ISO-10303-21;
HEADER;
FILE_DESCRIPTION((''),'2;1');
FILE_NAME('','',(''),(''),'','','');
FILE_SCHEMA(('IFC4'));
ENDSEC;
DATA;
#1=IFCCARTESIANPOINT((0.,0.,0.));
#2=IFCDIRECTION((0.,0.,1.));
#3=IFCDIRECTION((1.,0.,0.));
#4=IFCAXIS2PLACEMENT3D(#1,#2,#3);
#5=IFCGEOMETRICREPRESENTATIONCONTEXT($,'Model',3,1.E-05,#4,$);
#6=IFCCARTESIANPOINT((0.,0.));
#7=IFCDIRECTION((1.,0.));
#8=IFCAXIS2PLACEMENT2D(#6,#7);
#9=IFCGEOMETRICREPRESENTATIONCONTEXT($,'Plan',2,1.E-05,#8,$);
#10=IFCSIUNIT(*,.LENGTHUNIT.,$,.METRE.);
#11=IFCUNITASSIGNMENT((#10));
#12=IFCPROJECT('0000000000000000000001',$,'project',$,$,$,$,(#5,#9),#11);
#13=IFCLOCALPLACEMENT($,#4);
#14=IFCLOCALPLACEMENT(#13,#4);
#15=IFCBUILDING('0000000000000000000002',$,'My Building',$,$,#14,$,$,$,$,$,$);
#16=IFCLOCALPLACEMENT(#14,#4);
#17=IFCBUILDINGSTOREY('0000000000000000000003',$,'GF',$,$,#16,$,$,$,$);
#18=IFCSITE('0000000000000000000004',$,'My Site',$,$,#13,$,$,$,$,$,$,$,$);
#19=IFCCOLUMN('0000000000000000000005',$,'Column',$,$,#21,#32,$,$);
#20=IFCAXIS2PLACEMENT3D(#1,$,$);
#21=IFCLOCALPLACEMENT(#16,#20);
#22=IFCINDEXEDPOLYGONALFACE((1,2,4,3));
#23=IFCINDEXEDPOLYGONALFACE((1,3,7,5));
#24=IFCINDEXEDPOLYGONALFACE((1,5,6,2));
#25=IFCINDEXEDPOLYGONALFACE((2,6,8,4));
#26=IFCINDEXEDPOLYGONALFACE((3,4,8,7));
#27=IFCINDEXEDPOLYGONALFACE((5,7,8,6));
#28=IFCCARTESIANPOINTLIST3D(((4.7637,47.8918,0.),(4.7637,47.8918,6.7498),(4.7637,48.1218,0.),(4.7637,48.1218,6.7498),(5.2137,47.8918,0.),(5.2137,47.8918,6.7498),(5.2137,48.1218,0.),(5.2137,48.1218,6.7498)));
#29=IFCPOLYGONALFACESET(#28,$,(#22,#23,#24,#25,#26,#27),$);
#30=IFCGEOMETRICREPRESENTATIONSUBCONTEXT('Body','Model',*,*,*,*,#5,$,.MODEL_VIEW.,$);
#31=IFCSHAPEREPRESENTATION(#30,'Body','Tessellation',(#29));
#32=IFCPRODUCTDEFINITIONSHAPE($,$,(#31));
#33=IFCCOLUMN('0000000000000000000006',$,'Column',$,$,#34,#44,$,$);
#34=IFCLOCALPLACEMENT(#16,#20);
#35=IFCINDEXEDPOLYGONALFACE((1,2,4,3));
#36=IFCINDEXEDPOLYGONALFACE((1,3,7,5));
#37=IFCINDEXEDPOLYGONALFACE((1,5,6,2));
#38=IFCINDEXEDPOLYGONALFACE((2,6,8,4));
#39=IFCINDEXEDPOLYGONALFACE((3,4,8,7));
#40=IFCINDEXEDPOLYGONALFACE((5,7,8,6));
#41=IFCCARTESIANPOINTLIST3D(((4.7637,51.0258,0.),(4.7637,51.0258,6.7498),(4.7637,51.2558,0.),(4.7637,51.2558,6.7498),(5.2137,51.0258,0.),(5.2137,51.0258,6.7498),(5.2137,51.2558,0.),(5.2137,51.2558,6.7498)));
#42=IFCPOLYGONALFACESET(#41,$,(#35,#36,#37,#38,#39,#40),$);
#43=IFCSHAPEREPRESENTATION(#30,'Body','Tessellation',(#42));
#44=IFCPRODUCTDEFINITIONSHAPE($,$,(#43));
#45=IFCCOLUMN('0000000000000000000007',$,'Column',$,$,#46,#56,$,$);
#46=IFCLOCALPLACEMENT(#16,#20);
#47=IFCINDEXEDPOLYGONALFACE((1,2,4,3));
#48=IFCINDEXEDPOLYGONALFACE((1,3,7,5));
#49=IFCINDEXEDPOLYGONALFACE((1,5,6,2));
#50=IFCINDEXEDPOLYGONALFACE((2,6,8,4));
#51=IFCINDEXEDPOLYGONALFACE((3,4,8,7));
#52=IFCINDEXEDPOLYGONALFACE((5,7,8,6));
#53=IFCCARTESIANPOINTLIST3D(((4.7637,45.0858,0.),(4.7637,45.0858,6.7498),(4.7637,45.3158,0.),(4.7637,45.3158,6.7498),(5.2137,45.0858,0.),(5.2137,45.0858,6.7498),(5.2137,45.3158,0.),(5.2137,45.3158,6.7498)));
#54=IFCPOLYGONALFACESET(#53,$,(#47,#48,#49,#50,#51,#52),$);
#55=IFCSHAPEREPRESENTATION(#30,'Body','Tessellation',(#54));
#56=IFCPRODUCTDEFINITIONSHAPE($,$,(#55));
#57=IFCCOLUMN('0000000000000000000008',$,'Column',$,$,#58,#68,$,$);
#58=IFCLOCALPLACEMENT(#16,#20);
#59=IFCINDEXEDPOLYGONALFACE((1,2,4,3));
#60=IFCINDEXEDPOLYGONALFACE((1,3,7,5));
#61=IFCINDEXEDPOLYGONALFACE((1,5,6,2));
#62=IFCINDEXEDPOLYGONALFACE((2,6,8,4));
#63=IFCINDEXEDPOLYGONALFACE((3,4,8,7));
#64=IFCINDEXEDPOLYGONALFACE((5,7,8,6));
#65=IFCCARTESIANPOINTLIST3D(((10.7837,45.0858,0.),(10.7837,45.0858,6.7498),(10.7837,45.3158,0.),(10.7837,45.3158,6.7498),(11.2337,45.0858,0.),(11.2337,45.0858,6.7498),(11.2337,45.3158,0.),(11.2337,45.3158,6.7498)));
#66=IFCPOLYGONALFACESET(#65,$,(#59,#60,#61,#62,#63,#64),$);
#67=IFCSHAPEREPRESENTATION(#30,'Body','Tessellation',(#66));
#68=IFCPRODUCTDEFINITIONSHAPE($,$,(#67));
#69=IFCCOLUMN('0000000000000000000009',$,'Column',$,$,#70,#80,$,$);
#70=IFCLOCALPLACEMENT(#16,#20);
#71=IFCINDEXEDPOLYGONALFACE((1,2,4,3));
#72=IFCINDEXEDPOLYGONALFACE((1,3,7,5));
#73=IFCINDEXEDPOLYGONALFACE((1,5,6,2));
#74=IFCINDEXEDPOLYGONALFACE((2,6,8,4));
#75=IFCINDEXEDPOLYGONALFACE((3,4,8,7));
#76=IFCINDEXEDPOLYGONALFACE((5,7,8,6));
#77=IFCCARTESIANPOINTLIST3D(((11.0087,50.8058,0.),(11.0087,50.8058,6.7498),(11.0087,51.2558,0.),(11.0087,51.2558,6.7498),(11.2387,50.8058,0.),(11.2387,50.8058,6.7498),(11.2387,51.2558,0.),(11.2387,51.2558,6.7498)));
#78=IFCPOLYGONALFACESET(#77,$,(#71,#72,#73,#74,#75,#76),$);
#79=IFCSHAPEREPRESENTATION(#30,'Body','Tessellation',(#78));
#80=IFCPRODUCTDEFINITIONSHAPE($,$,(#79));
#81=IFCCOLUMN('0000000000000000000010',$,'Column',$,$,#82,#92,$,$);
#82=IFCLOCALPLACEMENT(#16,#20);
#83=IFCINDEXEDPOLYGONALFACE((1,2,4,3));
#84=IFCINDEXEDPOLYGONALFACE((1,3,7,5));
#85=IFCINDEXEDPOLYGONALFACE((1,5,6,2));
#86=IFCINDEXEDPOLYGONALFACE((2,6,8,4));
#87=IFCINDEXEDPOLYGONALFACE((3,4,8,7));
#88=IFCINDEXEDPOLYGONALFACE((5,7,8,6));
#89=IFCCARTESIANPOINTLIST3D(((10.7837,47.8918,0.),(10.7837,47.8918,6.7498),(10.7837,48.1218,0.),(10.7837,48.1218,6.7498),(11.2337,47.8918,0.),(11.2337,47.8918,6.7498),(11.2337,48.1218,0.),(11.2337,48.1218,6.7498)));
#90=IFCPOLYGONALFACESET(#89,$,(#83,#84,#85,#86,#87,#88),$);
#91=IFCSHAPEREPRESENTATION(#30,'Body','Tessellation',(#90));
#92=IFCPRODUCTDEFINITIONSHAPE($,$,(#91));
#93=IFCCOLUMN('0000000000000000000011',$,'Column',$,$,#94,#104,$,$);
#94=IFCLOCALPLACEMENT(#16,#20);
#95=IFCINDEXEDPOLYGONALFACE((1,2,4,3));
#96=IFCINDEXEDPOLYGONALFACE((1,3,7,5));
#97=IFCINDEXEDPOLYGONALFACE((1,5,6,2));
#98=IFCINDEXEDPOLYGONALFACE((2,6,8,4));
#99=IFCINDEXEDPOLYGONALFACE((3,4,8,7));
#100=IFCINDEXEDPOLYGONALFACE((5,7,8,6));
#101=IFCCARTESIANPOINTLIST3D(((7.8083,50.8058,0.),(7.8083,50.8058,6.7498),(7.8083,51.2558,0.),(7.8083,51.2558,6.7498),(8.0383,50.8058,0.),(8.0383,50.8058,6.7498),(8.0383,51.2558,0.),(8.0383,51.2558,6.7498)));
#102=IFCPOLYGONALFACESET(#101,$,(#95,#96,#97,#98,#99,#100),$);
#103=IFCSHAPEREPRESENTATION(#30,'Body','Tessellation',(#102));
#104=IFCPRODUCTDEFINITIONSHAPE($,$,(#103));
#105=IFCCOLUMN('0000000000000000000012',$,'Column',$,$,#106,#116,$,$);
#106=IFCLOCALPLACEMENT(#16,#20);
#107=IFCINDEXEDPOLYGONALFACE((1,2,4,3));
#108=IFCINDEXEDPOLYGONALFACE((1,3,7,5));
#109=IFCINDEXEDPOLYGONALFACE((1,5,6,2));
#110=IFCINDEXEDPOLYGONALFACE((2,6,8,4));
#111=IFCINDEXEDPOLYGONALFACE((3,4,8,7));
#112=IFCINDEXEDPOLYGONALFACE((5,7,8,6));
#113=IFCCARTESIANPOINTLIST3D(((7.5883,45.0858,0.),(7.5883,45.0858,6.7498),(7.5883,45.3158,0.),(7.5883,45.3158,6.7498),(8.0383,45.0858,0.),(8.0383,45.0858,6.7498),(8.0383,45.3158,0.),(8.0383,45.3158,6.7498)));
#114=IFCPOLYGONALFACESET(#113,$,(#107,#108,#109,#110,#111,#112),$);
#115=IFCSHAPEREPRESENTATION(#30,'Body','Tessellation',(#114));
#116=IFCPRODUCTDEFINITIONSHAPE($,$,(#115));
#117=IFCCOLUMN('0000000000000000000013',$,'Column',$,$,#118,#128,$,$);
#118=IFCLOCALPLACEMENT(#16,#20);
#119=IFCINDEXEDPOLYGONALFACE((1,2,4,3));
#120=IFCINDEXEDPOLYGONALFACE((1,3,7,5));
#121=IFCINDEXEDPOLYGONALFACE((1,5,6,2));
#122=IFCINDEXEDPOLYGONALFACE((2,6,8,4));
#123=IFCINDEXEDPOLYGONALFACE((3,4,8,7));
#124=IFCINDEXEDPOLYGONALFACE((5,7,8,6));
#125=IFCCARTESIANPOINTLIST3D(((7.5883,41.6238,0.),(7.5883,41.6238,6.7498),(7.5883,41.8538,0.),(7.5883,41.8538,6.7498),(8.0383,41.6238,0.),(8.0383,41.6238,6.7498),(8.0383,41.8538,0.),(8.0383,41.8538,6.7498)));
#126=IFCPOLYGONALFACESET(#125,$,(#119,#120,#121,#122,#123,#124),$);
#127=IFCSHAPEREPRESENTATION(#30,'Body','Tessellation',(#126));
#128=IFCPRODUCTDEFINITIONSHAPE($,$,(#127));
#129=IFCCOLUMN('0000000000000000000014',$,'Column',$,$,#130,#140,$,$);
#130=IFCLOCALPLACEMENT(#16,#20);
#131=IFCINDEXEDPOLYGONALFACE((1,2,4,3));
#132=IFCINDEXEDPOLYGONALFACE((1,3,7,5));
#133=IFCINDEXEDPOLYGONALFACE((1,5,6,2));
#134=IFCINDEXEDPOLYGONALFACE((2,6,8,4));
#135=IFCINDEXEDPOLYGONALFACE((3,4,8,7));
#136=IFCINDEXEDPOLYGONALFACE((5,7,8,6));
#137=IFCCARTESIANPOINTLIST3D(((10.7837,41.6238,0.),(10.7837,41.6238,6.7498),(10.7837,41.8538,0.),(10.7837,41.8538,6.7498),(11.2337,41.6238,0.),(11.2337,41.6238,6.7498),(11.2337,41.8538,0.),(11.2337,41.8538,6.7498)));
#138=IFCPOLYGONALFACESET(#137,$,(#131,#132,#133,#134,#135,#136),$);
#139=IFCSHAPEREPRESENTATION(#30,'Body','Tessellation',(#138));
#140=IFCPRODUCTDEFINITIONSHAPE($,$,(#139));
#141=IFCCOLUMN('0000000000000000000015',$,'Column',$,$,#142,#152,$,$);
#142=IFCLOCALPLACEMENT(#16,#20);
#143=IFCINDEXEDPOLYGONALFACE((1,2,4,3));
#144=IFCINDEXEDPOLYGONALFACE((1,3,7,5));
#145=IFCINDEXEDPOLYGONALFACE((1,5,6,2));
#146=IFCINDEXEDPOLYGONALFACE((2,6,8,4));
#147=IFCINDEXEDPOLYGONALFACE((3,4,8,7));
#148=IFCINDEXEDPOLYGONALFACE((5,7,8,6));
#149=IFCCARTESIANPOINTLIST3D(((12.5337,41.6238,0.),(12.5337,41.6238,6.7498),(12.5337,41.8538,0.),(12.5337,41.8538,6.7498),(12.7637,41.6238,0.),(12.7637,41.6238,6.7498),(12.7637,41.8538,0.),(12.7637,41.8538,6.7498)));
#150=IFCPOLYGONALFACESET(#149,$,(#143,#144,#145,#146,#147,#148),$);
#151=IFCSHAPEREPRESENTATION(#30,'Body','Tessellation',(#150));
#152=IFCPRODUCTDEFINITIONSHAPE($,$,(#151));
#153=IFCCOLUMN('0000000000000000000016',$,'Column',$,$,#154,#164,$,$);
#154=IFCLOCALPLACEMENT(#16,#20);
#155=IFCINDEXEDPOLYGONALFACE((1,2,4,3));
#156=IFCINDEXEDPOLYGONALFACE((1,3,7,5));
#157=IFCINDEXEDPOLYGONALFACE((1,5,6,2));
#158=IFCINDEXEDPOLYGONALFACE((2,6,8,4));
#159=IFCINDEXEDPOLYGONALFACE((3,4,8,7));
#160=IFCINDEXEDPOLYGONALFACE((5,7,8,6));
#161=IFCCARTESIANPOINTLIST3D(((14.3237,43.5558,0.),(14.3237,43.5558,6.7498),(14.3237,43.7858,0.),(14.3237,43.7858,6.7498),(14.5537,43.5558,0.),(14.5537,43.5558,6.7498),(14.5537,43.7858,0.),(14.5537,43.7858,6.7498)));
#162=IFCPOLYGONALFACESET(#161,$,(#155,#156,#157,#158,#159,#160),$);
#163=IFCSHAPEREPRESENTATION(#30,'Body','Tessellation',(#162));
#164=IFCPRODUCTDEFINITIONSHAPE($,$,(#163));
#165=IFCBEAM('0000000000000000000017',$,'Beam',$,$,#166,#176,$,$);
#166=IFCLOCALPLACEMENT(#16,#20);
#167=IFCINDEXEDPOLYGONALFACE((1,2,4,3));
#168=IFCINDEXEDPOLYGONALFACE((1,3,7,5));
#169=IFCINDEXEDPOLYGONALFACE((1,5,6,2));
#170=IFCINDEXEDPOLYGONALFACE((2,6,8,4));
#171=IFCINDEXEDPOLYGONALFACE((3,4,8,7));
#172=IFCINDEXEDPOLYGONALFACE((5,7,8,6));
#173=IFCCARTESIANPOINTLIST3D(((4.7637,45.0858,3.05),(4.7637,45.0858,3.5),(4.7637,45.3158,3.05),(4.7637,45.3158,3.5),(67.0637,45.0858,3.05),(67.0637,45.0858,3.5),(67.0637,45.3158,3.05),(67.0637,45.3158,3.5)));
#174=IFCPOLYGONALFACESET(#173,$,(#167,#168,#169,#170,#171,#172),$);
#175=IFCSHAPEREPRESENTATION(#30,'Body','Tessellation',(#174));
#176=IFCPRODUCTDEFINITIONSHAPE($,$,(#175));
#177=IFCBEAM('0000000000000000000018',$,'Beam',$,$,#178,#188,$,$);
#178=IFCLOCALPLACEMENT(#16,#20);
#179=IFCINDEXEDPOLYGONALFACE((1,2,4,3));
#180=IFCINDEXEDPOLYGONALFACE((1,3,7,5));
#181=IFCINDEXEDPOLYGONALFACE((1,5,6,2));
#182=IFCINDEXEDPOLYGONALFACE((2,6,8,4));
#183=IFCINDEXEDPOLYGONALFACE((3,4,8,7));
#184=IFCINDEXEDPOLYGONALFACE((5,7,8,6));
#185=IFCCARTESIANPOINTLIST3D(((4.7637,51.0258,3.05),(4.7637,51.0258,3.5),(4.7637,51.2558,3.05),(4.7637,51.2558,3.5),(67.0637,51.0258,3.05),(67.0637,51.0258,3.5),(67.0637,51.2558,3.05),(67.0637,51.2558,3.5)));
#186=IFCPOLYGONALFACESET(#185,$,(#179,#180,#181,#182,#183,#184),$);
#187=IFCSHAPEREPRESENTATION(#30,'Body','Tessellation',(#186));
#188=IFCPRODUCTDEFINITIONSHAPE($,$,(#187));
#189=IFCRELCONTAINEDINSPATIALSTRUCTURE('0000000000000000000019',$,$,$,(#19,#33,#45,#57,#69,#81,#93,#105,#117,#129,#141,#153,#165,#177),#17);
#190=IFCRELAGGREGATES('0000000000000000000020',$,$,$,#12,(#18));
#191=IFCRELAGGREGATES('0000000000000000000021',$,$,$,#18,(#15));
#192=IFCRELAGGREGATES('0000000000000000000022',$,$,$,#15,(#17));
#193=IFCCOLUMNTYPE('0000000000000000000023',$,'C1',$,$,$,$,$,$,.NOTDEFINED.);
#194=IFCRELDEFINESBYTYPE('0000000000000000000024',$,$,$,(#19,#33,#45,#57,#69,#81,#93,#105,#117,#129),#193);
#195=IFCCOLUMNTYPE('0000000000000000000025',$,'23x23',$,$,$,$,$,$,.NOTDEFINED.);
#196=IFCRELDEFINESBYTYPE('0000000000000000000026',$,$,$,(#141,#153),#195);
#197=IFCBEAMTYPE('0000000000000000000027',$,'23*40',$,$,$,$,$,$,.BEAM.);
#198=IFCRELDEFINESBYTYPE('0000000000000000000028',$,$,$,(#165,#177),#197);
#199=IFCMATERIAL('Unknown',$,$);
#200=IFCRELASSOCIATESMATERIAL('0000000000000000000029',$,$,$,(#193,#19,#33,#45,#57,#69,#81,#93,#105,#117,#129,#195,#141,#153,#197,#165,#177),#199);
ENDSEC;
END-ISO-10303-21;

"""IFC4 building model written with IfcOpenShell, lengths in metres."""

from ifc_helpers import new_model, si_unit, frame, origin_with_axes, origin_2d_with_axis, place, context, subcontext, project, spatial, rectangle, extrude, material, material_profile, profile_set, profile_usage, type_object, element, save


model = new_model("IFC4")

# Units and contexts
model_context = context("Model", 3, precision=1e-05, world=origin_with_axes())
plan_context = context("Plan", 2, precision=1e-05, world=origin_2d_with_axis())
body_context = subcontext(model_context, "Body", "Model", "MODEL_VIEW")
ifc_project = project(units=[si_unit("LENGTHUNIT", "METRE")], contexts=[model_context, plan_context])

# Site, building, storey
site_placement = place(None, origin_with_axes())
site = spatial("IfcSite", under=ifc_project, at=site_placement, Name="My Site")
building_placement = place(site_placement, origin_with_axes())
building = spatial("IfcBuilding", under=site, at=building_placement, Name="My Building")
storey_placement = place(building_placement, origin_with_axes())
storey = spatial("IfcBuildingStorey", under=building, at=storey_placement, Name="GF")

# Columns
ifc_material = material(Name="Unknown")
ifc_material_profile_1 = material_profile(ifc_material, rectangle(XDim=0.45, YDim=0.23))
ifc_profile_set_1 = profile_set([ifc_material_profile_1])
ifc_profile_usage_1 = profile_usage(ifc_profile_set_1, cardinal=5)
column_type_1 = type_object("IfcColumnType", Name="C1", PredefinedType="NOTDEFINED", material=ifc_profile_set_1)
column_1_placement = place(storey_placement, frame((4.9887, 48.0068, 0.0), z_axis=(0.0, 0.0, 1.0), x_axis=(1.0, 0.0, 0.0)))
element("IfcColumn", 1, at=column_1_placement, inside=storey, type_object=column_type_1, material=ifc_profile_usage_1, Name="Column", context=body_context, shape_type="SweptSolid", body=[
    extrude(rectangle(XDim=0.45, YDim=0.23), origin_with_axes(), (0.0, 0.0, 1.0), 6.7498),
])
ifc_profile_usage_2 = profile_usage(ifc_profile_set_1, cardinal=5)
column_2_placement = place(storey_placement, frame((4.9887, 51.1408, 0.0), z_axis=(0.0, 0.0, 1.0), x_axis=(1.0, 0.0, 0.0)))
element("IfcColumn", 2, at=column_2_placement, inside=storey, type_object=column_type_1, material=ifc_profile_usage_2, Name="Column", context=body_context, shape_type="SweptSolid", body=[
    extrude(rectangle(XDim=0.45, YDim=0.23), origin_with_axes(), (0.0, 0.0, 1.0), 6.7498),
])
ifc_profile_usage_3 = profile_usage(ifc_profile_set_1, cardinal=5)
column_3_placement = place(storey_placement, frame((4.9887, 45.2008, 0.0), z_axis=(0.0, 0.0, 1.0), x_axis=(1.0, 0.0, 0.0)))
element("IfcColumn", 3, at=column_3_placement, inside=storey, type_object=column_type_1, material=ifc_profile_usage_3, Name="Column", context=body_context, shape_type="SweptSolid", body=[
    extrude(rectangle(XDim=0.45, YDim=0.23), origin_with_axes(), (0.0, 0.0, 1.0), 6.7498),
])
ifc_profile_usage_4 = profile_usage(ifc_profile_set_1, cardinal=5)
column_4_placement = place(storey_placement, frame((11.0087, 45.2008, 0.0), z_axis=(0.0, 0.0, 1.0), x_axis=(-1.0, 0.0, 0.0)))
element("IfcColumn", 4, at=column_4_placement, inside=storey, type_object=column_type_1, material=ifc_profile_usage_4, Name="Column", context=body_context, shape_type="SweptSolid", body=[
    extrude(rectangle(XDim=0.45, YDim=0.23), origin_with_axes(), (0.0, 0.0, 1.0), 6.7498),
])
ifc_profile_usage_5 = profile_usage(ifc_profile_set_1, cardinal=5)
column_5_placement = place(storey_placement, frame((11.1237, 51.0308, 0.0), z_axis=(0.0, 0.0, 1.0), x_axis=(0.0, 1.0, 0.0)))
element("IfcColumn", 5, at=column_5_placement, inside=storey, type_object=column_type_1, material=ifc_profile_usage_5, Name="Column", context=body_context, shape_type="SweptSolid", body=[
    extrude(rectangle(XDim=0.45, YDim=0.23), origin_with_axes(), (0.0, 0.0, 1.0), 6.7498),
])
ifc_profile_usage_6 = profile_usage(ifc_profile_set_1, cardinal=5)
column_6_placement = place(storey_placement, frame((11.0087, 48.0068, 0.0), z_axis=(0.0, 0.0, 1.0), x_axis=(-1.0, 0.0, 0.0)))
element("IfcColumn", 6, at=column_6_placement, inside=storey, type_object=column_type_1, material=ifc_profile_usage_6, Name="Column", context=body_context, shape_type="SweptSolid", body=[
    extrude(rectangle(XDim=0.45, YDim=0.23), origin_with_axes(), (0.0, 0.0, 1.0), 6.7498),
])
ifc_profile_usage_7 = profile_usage(ifc_profile_set_1, cardinal=5)
column_7_placement = place(storey_placement, frame((7.9233, 51.0308, 0.0), z_axis=(0.0, 0.0, 1.0), x_axis=(0.0, 1.0, 0.0)))
element("IfcColumn", 7, at=column_7_placement, inside=storey, type_object=column_type_1, material=ifc_profile_usage_7, Name="Column", context=body_context, shape_type="SweptSolid", body=[
    extrude(rectangle(XDim=0.45, YDim=0.23), origin_with_axes(), (0.0, 0.0, 1.0), 6.7498),
])
ifc_profile_usage_8 = profile_usage(ifc_profile_set_1, cardinal=5)
column_8_placement = place(storey_placement, frame((7.8133, 45.2008, 0.0), z_axis=(0.0, 0.0, 1.0), x_axis=(-1.0, 0.0, 0.0)))
element("IfcColumn", 8, at=column_8_placement, inside=storey, type_object=column_type_1, material=ifc_profile_usage_8, Name="Column", context=body_context, shape_type="SweptSolid", body=[
    extrude(rectangle(XDim=0.45, YDim=0.23), origin_with_axes(), (0.0, 0.0, 1.0), 6.7498),
])
ifc_profile_usage_9 = profile_usage(ifc_profile_set_1, cardinal=5)
column_9_placement = place(storey_placement, frame((7.8133, 41.7388, 0.0), z_axis=(0.0, 0.0, 1.0), x_axis=(-1.0, 0.0, 0.0)))
element("IfcColumn", 9, at=column_9_placement, inside=storey, type_object=column_type_1, material=ifc_profile_usage_9, Name="Column", context=body_context, shape_type="SweptSolid", body=[
    extrude(rectangle(XDim=0.45, YDim=0.23), origin_with_axes(), (0.0, 0.0, 1.0), 6.7498),
])
ifc_profile_usage_10 = profile_usage(ifc_profile_set_1, cardinal=5)
column_10_placement = place(storey_placement, frame((11.0087, 41.7388, 0.0), z_axis=(0.0, 0.0, 1.0), x_axis=(-1.0, 0.0, 0.0)))
element("IfcColumn", 10, at=column_10_placement, inside=storey, type_object=column_type_1, material=ifc_profile_usage_10, Name="Column", context=body_context, shape_type="SweptSolid", body=[
    extrude(rectangle(XDim=0.45, YDim=0.23), origin_with_axes(), (0.0, 0.0, 1.0), 6.7498),
])
ifc_material_profile_2 = material_profile(ifc_material, rectangle(XDim=0.23, YDim=0.23))
ifc_profile_set_2 = profile_set([ifc_material_profile_2])
ifc_profile_usage_11 = profile_usage(ifc_profile_set_2, cardinal=5)
column_type_2 = type_object("IfcColumnType", Name="23x23", PredefinedType="NOTDEFINED", material=ifc_profile_set_2)
column_11_placement = place(storey_placement, frame((12.6487, 41.7388, 0.0), z_axis=(0.0, 0.0, 1.0), x_axis=(1.0, 0.0, 0.0)))
element("IfcColumn", 11, at=column_11_placement, inside=storey, type_object=column_type_2, material=ifc_profile_usage_11, Name="Column", context=body_context, shape_type="SweptSolid", body=[
    extrude(rectangle(XDim=0.23, YDim=0.23), origin_with_axes(), (0.0, 0.0, 1.0), 6.7498),
])
ifc_profile_usage_12 = profile_usage(ifc_profile_set_2, cardinal=5)
column_12_placement = place(storey_placement, frame((14.4387, 43.6708, 0.0), z_axis=(0.0, 0.0, 1.0), x_axis=(1.0, 0.0, 0.0)))
element("IfcColumn", 12, at=column_12_placement, inside=storey, type_object=column_type_2, material=ifc_profile_usage_12, Name="Column", context=body_context, shape_type="SweptSolid", body=[
    extrude(rectangle(XDim=0.23, YDim=0.23), origin_with_axes(), (0.0, 0.0, 1.0), 6.7498),
])

# Beams
ifc_material_profile_3 = material_profile(ifc_material, rectangle(XDim=0.23, YDim=0.45))
ifc_profile_set_3 = profile_set([ifc_material_profile_3])
ifc_profile_usage_13 = profile_usage(ifc_profile_set_3, cardinal=5)
beam_type = type_object("IfcBeamType", Name="23*40", PredefinedType="BEAM", material=ifc_profile_set_3)
beam_1_placement = place(storey_placement, frame((4.7637, 45.2008, 3.275), z_axis=(1.0, 0.0, 0.0), x_axis=(0.0, 1.0, 0.0)))
element("IfcBeam", 13, at=beam_1_placement, inside=storey, type_object=beam_type, material=ifc_profile_usage_13, Name="Beam", context=body_context, shape_type="SweptSolid", body=[
    extrude(rectangle(XDim=0.23, YDim=0.45), origin_with_axes(), (0.0, 0.0, 1.0), 62.3),
])
ifc_profile_usage_14 = profile_usage(ifc_profile_set_3, cardinal=5)
beam_2_placement = place(storey_placement, frame((4.7637, 51.1408, 3.275), z_axis=(1.0, 0.0, 0.0), x_axis=(0.0, 1.0, 0.0)))
element("IfcBeam", 14, at=beam_2_placement, inside=storey, type_object=beam_type, material=ifc_profile_usage_14, Name="Beam", context=body_context, shape_type="SweptSolid", body=[
    extrude(rectangle(XDim=0.23, YDim=0.45), origin_with_axes(), (0.0, 0.0, 1.0), 62.3),
])

save(model, "model.ifc")
